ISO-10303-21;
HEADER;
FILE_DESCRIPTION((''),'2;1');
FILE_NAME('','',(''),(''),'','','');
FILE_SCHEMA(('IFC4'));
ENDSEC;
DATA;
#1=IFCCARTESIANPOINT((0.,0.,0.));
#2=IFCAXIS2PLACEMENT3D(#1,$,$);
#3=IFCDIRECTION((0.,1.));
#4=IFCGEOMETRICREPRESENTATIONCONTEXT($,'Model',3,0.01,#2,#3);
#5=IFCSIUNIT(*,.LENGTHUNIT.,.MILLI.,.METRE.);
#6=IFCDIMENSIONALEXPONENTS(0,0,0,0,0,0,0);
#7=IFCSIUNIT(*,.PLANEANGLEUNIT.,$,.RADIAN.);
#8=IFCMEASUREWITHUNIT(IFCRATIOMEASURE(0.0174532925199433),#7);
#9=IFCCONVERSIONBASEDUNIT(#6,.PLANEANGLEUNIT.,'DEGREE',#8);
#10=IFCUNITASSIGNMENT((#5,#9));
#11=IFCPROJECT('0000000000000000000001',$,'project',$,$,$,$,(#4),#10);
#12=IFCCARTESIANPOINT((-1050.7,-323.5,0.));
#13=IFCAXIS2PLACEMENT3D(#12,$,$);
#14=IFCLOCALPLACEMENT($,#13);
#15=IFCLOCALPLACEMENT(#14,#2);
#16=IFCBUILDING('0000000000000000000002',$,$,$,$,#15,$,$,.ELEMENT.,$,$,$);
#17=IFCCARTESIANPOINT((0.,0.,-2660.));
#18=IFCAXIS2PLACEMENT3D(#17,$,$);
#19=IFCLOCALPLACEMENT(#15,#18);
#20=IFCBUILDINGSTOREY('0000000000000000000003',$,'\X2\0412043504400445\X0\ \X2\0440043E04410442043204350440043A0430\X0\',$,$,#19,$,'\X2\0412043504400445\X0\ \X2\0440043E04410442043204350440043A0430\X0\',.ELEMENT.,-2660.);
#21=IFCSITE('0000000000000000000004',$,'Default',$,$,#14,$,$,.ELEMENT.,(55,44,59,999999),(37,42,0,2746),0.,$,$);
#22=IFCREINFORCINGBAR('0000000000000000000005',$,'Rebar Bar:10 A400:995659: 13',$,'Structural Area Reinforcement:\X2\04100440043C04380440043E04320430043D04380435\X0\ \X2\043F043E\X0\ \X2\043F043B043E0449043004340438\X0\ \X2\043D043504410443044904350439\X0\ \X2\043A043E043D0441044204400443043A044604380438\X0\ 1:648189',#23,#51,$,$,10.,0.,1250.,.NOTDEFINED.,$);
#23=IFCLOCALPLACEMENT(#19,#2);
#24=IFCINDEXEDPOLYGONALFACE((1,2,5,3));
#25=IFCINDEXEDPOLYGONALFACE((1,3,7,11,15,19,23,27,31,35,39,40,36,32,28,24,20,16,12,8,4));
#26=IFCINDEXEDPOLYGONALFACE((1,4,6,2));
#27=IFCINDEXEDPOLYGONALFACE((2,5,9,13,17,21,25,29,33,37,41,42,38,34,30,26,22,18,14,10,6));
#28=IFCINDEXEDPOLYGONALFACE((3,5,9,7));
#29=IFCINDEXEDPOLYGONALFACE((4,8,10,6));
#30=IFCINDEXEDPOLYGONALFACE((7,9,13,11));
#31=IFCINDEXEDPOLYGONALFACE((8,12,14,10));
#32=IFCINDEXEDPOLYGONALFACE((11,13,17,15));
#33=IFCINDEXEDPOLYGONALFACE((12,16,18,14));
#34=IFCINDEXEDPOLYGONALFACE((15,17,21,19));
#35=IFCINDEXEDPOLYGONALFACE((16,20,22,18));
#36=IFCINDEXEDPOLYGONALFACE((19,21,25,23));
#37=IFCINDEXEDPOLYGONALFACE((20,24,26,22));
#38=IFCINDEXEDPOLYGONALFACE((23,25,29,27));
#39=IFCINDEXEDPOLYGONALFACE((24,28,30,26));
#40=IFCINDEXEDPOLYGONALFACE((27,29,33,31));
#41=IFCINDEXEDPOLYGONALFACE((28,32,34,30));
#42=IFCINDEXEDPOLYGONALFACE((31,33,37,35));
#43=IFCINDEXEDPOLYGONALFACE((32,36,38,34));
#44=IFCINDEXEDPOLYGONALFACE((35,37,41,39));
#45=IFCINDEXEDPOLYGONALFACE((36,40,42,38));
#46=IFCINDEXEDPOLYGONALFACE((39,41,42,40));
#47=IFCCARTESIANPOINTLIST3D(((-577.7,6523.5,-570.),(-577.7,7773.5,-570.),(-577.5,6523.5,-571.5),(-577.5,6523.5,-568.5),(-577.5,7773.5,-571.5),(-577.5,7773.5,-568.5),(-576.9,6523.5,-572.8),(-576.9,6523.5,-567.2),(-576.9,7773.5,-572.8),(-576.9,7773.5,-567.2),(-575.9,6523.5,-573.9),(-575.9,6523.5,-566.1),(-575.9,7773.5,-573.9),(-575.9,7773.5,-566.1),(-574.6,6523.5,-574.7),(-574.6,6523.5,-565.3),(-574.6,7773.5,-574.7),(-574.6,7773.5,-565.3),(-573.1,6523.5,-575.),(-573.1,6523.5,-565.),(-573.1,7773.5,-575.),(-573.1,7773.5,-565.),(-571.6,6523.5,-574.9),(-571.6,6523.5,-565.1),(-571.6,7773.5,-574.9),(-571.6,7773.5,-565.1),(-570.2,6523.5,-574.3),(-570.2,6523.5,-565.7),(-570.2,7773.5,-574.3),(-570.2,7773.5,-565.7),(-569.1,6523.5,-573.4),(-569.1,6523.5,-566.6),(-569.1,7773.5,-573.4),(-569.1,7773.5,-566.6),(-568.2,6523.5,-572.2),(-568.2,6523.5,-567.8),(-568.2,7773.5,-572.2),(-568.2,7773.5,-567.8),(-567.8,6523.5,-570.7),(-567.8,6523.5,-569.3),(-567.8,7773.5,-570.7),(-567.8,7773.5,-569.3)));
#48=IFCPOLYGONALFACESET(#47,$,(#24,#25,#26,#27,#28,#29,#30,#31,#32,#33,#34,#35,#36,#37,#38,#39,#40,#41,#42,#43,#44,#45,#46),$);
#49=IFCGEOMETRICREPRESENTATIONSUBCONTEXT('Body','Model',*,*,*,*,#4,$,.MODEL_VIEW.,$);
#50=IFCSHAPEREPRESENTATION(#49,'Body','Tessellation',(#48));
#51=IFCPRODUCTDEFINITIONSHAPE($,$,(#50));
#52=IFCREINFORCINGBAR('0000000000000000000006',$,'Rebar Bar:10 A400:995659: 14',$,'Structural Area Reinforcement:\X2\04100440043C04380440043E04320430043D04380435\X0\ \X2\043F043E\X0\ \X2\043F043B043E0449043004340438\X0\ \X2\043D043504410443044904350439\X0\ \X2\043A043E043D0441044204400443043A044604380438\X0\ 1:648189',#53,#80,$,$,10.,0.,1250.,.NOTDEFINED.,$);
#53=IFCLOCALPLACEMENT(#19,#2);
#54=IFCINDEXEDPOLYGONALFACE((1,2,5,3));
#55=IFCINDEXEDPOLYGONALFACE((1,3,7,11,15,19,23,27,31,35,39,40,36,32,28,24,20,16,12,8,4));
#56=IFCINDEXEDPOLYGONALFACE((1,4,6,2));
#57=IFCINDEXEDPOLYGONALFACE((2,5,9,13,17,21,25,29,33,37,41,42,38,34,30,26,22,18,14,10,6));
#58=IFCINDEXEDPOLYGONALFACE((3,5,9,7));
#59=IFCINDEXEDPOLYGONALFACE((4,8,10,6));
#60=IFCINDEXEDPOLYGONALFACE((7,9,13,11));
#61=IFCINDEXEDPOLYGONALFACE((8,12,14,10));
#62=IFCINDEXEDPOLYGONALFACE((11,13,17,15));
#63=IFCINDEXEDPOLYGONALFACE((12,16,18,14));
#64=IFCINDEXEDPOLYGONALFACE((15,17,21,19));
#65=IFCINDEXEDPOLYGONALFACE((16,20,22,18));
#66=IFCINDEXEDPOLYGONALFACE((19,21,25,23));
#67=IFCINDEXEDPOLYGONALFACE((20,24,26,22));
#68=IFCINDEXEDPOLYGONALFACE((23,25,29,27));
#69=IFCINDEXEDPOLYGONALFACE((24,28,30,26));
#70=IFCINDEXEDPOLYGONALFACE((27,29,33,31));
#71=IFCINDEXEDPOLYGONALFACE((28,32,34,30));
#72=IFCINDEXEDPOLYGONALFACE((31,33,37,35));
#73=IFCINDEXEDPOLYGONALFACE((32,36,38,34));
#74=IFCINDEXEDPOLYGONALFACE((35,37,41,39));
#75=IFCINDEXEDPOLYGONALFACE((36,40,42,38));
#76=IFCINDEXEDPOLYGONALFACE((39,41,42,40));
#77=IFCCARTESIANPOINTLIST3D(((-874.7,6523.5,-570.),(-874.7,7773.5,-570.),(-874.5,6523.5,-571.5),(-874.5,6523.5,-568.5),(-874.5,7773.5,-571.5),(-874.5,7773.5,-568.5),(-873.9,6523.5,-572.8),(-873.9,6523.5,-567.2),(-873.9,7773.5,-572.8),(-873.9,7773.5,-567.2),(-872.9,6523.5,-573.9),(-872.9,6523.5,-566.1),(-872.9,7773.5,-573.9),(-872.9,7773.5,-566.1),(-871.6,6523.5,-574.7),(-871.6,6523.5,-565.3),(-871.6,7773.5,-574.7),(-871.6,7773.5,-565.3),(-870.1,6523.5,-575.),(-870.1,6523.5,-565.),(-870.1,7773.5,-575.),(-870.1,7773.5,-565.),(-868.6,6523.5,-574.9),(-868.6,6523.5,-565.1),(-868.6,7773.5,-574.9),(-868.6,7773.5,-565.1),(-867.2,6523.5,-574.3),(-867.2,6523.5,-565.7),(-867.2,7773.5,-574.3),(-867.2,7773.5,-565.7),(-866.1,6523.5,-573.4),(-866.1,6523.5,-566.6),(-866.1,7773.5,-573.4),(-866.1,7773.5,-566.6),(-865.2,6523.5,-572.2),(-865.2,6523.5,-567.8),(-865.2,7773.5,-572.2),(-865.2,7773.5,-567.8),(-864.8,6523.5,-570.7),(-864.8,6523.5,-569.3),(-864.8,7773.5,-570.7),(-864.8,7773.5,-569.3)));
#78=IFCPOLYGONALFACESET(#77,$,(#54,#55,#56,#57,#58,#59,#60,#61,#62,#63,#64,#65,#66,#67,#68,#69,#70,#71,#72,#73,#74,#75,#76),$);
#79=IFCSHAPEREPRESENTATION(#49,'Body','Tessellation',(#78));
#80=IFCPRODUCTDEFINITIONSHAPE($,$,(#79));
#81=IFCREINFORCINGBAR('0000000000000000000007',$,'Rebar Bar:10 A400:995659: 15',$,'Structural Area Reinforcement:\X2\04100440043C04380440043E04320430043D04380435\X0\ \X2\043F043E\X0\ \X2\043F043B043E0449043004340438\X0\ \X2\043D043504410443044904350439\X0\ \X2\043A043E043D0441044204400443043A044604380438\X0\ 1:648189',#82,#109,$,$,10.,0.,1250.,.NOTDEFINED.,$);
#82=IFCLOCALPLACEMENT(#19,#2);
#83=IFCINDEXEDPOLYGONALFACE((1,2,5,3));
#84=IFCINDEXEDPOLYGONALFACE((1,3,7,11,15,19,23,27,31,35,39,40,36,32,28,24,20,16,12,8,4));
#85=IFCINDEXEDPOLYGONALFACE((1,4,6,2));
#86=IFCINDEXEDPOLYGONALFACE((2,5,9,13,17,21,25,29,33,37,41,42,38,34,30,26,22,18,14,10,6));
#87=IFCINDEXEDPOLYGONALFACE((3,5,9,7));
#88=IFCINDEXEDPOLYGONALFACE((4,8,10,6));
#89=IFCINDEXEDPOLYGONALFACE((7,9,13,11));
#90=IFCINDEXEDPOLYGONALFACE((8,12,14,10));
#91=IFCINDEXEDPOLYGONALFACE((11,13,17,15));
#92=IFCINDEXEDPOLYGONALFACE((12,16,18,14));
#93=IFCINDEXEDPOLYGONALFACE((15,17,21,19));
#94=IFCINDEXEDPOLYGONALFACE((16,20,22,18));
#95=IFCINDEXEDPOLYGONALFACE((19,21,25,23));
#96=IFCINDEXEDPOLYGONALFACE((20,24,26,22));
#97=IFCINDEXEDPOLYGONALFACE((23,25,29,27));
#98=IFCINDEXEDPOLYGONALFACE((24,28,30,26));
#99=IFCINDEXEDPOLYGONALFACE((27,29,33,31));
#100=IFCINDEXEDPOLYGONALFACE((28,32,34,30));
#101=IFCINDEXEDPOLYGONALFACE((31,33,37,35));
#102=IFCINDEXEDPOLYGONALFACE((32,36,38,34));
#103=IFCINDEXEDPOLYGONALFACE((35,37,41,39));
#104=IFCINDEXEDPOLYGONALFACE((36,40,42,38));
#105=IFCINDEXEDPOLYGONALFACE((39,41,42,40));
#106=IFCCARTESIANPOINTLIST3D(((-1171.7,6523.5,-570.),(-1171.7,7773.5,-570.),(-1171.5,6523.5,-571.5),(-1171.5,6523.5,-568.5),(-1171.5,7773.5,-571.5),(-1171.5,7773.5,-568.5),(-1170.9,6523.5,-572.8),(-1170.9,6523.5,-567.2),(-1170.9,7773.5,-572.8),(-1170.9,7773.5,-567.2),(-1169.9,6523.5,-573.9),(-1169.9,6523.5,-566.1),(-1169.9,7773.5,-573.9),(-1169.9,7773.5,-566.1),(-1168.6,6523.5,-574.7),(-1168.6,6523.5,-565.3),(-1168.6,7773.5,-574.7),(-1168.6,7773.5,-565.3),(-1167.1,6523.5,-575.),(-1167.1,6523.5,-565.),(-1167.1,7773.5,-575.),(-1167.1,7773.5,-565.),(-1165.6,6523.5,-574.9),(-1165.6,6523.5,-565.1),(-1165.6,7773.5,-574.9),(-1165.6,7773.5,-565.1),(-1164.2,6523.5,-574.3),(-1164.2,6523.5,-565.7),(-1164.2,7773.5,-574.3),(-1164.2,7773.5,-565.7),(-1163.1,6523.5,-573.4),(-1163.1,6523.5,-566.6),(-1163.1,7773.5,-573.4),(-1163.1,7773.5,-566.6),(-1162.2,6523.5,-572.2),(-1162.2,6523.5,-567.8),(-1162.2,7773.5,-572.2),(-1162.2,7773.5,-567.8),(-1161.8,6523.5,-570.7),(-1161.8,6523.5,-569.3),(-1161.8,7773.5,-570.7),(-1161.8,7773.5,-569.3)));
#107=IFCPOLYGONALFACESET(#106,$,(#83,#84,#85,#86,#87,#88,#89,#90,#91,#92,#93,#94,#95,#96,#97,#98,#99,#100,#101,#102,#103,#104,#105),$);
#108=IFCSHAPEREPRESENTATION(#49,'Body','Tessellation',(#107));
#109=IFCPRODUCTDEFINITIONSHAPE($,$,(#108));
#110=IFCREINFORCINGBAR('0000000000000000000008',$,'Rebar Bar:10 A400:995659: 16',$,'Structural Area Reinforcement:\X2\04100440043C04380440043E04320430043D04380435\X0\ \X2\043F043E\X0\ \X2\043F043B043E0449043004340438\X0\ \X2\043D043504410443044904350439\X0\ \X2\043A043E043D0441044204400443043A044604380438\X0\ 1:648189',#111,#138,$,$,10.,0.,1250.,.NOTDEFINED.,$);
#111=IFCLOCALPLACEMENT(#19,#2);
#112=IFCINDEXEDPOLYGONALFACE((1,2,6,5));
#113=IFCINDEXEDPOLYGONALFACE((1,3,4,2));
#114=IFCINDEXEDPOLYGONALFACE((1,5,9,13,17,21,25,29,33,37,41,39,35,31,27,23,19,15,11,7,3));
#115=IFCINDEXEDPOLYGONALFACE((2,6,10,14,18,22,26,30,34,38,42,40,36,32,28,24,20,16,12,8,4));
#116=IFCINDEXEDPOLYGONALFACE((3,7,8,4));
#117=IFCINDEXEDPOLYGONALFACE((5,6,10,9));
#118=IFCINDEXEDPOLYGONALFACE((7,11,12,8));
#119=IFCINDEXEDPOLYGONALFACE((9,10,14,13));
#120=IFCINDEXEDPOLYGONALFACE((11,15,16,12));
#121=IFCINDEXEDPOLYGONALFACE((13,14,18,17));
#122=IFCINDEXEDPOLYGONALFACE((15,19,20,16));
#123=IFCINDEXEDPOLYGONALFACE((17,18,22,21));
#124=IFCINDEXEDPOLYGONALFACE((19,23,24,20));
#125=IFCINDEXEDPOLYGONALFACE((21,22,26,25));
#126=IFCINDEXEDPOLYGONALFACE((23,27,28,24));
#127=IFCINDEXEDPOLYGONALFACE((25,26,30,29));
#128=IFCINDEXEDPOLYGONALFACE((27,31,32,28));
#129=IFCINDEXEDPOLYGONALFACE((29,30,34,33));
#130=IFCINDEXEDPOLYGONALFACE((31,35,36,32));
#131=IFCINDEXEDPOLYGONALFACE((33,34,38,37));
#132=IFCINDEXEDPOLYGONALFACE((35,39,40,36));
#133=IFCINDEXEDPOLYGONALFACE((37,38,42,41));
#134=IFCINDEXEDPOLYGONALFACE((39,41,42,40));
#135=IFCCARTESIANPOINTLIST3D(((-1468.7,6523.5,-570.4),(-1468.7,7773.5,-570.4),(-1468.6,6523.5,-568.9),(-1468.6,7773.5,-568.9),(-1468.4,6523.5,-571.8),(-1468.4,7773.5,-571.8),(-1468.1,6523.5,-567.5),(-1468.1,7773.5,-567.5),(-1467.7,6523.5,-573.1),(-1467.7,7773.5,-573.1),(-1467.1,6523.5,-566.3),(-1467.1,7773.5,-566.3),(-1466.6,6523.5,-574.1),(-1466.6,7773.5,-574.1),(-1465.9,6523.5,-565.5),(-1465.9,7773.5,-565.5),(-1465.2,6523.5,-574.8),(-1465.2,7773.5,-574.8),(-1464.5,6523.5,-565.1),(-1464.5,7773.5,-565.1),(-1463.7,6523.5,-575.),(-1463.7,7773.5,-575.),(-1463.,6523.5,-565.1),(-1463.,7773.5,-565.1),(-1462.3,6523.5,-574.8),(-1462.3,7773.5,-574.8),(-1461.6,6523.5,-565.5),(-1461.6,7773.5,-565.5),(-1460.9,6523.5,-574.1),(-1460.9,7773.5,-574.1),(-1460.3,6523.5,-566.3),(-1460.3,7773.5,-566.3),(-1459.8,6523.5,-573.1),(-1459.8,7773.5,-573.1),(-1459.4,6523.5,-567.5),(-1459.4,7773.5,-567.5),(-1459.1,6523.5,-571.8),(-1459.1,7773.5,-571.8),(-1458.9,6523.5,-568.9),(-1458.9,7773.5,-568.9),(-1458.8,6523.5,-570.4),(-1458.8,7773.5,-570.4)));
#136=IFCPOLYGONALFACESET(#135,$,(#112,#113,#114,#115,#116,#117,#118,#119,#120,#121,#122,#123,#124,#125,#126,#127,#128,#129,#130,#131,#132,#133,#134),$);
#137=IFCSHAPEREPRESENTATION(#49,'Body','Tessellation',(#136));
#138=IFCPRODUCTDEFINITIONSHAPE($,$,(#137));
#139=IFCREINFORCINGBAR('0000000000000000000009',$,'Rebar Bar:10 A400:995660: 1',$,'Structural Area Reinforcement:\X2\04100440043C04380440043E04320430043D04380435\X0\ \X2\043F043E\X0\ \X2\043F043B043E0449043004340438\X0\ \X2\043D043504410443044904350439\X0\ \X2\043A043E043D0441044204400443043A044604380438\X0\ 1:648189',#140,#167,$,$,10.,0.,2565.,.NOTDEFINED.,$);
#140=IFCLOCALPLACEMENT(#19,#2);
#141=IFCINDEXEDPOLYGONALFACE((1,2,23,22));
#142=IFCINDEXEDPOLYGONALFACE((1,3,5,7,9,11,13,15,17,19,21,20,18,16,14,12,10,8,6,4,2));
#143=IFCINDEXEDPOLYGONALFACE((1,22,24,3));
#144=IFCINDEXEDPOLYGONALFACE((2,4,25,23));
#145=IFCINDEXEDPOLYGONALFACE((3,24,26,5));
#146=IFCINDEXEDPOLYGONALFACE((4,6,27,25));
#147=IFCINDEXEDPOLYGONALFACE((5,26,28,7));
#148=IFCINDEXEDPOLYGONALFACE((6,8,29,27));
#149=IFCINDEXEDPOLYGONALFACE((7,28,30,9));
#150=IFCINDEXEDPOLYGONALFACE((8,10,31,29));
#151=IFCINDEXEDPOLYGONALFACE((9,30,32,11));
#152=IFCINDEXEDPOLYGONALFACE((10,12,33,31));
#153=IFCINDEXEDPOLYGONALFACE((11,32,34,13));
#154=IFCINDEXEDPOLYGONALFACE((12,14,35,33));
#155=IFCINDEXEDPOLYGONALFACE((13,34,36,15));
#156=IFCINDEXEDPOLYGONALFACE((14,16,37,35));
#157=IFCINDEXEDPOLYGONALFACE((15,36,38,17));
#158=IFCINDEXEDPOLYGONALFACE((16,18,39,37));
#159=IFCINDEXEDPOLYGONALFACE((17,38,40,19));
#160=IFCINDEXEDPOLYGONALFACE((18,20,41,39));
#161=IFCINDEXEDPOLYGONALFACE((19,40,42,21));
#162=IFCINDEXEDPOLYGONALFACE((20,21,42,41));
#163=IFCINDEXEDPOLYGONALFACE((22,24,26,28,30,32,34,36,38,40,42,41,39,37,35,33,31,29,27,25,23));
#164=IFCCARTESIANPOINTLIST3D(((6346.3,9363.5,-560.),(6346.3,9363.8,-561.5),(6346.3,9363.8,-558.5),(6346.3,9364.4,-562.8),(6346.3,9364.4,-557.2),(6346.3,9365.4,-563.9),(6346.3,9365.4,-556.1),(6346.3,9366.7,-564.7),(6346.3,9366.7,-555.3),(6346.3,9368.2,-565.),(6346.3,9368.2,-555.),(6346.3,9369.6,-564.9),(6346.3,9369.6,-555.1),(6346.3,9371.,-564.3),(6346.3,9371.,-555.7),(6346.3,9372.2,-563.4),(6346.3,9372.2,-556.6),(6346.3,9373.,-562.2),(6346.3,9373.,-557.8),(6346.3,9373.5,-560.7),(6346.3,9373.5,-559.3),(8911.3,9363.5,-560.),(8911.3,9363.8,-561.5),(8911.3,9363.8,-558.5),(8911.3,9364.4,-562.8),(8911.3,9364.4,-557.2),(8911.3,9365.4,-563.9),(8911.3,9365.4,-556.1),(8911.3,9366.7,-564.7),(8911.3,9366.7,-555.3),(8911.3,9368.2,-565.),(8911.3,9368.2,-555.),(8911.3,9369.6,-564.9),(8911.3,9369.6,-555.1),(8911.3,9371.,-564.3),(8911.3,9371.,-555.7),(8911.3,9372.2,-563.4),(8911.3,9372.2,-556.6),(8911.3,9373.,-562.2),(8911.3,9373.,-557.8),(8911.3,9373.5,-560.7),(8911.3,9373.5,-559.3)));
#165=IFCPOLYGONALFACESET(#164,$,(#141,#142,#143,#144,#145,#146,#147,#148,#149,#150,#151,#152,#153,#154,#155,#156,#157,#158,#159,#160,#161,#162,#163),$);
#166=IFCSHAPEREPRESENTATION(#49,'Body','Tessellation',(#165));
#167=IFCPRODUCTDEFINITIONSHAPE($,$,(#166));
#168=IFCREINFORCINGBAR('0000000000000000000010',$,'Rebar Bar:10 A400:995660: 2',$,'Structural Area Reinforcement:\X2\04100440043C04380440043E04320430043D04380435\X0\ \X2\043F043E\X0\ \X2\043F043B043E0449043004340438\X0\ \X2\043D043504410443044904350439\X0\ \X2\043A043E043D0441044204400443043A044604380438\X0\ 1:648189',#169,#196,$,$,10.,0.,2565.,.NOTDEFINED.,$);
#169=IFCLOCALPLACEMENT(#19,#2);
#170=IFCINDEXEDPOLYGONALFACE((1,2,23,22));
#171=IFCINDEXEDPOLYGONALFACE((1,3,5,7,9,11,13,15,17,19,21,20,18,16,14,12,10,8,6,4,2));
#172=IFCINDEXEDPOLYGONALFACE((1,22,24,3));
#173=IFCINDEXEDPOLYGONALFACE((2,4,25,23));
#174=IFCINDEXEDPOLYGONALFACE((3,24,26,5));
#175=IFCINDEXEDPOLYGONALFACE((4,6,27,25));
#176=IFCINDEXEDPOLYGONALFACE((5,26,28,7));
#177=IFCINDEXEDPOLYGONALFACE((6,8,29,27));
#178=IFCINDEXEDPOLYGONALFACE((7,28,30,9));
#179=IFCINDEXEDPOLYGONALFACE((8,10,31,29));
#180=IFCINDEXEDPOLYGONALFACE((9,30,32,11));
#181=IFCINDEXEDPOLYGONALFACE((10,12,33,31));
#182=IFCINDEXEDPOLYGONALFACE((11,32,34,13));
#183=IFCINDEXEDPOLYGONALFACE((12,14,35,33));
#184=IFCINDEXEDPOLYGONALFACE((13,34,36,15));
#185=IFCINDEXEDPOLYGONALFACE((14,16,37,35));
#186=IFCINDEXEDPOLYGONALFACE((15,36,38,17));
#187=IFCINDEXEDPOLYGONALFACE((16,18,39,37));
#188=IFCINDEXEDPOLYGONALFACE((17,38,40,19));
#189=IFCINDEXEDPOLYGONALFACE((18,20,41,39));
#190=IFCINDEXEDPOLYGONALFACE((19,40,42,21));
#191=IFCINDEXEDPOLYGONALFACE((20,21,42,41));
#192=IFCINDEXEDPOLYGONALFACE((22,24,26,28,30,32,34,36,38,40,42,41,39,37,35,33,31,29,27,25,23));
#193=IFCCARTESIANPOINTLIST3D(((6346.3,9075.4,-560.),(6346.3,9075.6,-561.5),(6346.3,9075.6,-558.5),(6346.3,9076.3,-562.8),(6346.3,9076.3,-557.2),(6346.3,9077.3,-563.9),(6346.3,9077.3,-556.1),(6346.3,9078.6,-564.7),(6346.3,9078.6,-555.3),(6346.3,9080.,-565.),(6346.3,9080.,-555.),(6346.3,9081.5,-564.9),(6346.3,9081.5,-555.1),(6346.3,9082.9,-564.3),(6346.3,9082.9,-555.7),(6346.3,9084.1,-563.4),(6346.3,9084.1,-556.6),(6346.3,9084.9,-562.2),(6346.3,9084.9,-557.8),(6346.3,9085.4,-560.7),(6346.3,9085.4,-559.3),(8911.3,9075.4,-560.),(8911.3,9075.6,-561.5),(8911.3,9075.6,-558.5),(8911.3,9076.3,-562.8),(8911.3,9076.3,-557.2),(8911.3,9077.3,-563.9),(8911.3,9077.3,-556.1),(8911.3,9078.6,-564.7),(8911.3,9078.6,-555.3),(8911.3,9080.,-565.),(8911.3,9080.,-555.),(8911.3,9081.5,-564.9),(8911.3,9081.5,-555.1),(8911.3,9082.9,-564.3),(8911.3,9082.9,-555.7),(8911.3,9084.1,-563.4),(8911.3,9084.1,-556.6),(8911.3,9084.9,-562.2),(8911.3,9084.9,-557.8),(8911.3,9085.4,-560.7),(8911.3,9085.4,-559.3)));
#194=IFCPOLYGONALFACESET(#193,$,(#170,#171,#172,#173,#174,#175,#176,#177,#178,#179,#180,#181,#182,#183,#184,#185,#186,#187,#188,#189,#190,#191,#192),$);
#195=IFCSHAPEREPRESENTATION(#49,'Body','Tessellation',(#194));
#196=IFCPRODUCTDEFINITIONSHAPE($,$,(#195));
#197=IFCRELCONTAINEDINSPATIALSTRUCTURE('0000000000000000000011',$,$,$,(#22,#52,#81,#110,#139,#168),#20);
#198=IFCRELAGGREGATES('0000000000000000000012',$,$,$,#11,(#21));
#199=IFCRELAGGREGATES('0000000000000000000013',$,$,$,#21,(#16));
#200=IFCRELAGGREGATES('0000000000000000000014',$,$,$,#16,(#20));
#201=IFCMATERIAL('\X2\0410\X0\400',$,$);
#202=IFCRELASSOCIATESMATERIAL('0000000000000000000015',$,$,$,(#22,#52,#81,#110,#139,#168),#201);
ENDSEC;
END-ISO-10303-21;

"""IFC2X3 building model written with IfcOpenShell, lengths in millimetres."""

from ifc_helpers import new_model, entity, si_unit, converted_unit, direction, frame, origin, place, context, subcontext, project, spatial, material, element, save


model = new_model("IFC2X3")

# Units and contexts
model_context = context("Model", 3, precision=0.01, world=origin(), true_north=direction((0.0, 1.0)))
body_context = subcontext(model_context, "Body", "Model", "MODEL_VIEW")
ifc_project = project(units=[si_unit("LENGTHUNIT", "METRE", prefix="MILLI"), converted_unit("PLANEANGLEUNIT", "DEGREE", entity("IfcRatioMeasure", 0.0174532925199433), si_unit("PLANEANGLEUNIT", "RADIAN"), dimensions=[0, 0, 0, 0, 0, 0, 0])], contexts=[model_context])

# Site, building, storey
site_placement = place(None, frame((-1050.7, -323.5, 0.0)))
site = spatial("IfcSite", under=ifc_project, at=site_placement, Name="Default", CompositionType="ELEMENT", RefLatitude=(55, 44, 59, 999999), RefLongitude=(37, 42, 0, 2746), RefElevation=0.0)
building_placement = place(site_placement, origin())
building = spatial("IfcBuilding", under=site, at=building_placement, CompositionType="ELEMENT")
storey_placement = place(building_placement, frame((0.0, 0.0, -2660.0)))
storey = spatial("IfcBuildingStorey", under=building, at=storey_placement, Name="Верх ростверка", LongName="Верх ростверка", CompositionType="ELEMENT", Elevation=-2660.0)

# Reinforcing bars
ifc_material = material(Name="А400")
reinforcing_bar_1_placement = place(storey_placement, origin())
element("IfcReinforcingBar", 1, at=reinforcing_bar_1_placement, inside=storey, material=ifc_material, Name="Rebar Bar:10 A400:995659: 13", ObjectType="Structural Area Reinforcement:Армирование по площади несущей конструкции 1:648189", BarLength=1250.0, BarRole="NOTDEFINED", CrossSectionArea=0.0, NominalDiameter=10.0, context=body_context, shape_type="AdvancedSweptSolid", body=[
    entity("IfcSweptDiskSolid", entity("IfcCompositeCurve", [entity("IfcCompositeCurveSegment", "CONTINUOUS", True, entity("IfcPolyline", [entity("IfcCartesianPoint", [-572.7, 7773.5, -570.0]), entity("IfcCartesianPoint", [-572.7, 6523.5, -570.0])]))], False), 5.0, None, 0.0, 1.0),
])
reinforcing_bar_2_placement = place(storey_placement, origin())
element("IfcReinforcingBar", 2, at=reinforcing_bar_2_placement, inside=storey, material=ifc_material, Name="Rebar Bar:10 A400:995659: 14", ObjectType="Structural Area Reinforcement:Армирование по площади несущей конструкции 1:648189", BarLength=1250.0, BarRole="NOTDEFINED", CrossSectionArea=0.0, NominalDiameter=10.0, context=body_context, shape_type="AdvancedSweptSolid", body=[
    entity("IfcSweptDiskSolid", entity("IfcCompositeCurve", [entity("IfcCompositeCurveSegment", "CONTINUOUS", True, entity("IfcPolyline", [entity("IfcCartesianPoint", [-869.7, 7773.5, -570.0]), entity("IfcCartesianPoint", [-869.7, 6523.5, -570.0])]))], False), 5.0, None, 0.0, 1.0),
])
reinforcing_bar_3_placement = place(storey_placement, origin())
element("IfcReinforcingBar", 3, at=reinforcing_bar_3_placement, inside=storey, material=ifc_material, Name="Rebar Bar:10 A400:995659: 15", ObjectType="Structural Area Reinforcement:Армирование по площади несущей конструкции 1:648189", BarLength=1250.0, BarRole="NOTDEFINED", CrossSectionArea=0.0, NominalDiameter=10.0, context=body_context, shape_type="AdvancedSweptSolid", body=[
    entity("IfcSweptDiskSolid", entity("IfcCompositeCurve", [entity("IfcCompositeCurveSegment", "CONTINUOUS", True, entity("IfcPolyline", [entity("IfcCartesianPoint", [-1166.7, 7773.5, -570.0]), entity("IfcCartesianPoint", [-1166.7, 6523.5, -570.0])]))], False), 5.0, None, 0.0, 1.0),
])
reinforcing_bar_4_placement = place(storey_placement, origin())
element("IfcReinforcingBar", 4, at=reinforcing_bar_4_placement, inside=storey, material=ifc_material, Name="Rebar Bar:10 A400:995659: 16", ObjectType="Structural Area Reinforcement:Армирование по площади несущей конструкции 1:648189", BarLength=1250.0, BarRole="NOTDEFINED", CrossSectionArea=0.0, NominalDiameter=10.0, context=body_context, shape_type="AdvancedSweptSolid", body=[
    entity("IfcSweptDiskSolid", entity("IfcCompositeCurve", [entity("IfcCompositeCurveSegment", "CONTINUOUS", True, entity("IfcPolyline", [entity("IfcCartesianPoint", [-1463.7, 7773.5, -570.0]), entity("IfcCartesianPoint", [-1463.7, 6523.5, -570.0])]))], False), 5.0, None, 0.0, 1.0),
])
reinforcing_bar_5_placement = place(storey_placement, origin())
element("IfcReinforcingBar", 5, at=reinforcing_bar_5_placement, inside=storey, material=ifc_material, Name="Rebar Bar:10 A400:995660: 1", ObjectType="Structural Area Reinforcement:Армирование по площади несущей конструкции 1:648189", BarLength=2565.0, BarRole="NOTDEFINED", CrossSectionArea=0.0, NominalDiameter=10.0, context=body_context, shape_type="AdvancedSweptSolid", body=[
    entity("IfcSweptDiskSolid", entity("IfcCompositeCurve", [entity("IfcCompositeCurveSegment", "CONTINUOUS", True, entity("IfcPolyline", [entity("IfcCartesianPoint", [8911.3, 9368.5, -560.0]), entity("IfcCartesianPoint", [6346.3, 9368.5, -560.0])]))], False), 5.0, None, 0.0, 1.0),
])
reinforcing_bar_6_placement = place(storey_placement, origin())
element("IfcReinforcingBar", 6, at=reinforcing_bar_6_placement, inside=storey, material=ifc_material, Name="Rebar Bar:10 A400:995660: 2", ObjectType="Structural Area Reinforcement:Армирование по площади несущей конструкции 1:648189", BarLength=2565.0, BarRole="NOTDEFINED", CrossSectionArea=0.0, NominalDiameter=10.0, context=body_context, shape_type="AdvancedSweptSolid", body=[
    entity("IfcSweptDiskSolid", entity("IfcCompositeCurve", [entity("IfcCompositeCurveSegment", "CONTINUOUS", True, entity("IfcPolyline", [entity("IfcCartesianPoint", [8911.3, 9080.4, -560.0]), entity("IfcCartesianPoint", [6346.3, 9080.4, -560.0])]))], False), 5.0, None, 0.0, 1.0),
])

save(model, "model.ifc")
